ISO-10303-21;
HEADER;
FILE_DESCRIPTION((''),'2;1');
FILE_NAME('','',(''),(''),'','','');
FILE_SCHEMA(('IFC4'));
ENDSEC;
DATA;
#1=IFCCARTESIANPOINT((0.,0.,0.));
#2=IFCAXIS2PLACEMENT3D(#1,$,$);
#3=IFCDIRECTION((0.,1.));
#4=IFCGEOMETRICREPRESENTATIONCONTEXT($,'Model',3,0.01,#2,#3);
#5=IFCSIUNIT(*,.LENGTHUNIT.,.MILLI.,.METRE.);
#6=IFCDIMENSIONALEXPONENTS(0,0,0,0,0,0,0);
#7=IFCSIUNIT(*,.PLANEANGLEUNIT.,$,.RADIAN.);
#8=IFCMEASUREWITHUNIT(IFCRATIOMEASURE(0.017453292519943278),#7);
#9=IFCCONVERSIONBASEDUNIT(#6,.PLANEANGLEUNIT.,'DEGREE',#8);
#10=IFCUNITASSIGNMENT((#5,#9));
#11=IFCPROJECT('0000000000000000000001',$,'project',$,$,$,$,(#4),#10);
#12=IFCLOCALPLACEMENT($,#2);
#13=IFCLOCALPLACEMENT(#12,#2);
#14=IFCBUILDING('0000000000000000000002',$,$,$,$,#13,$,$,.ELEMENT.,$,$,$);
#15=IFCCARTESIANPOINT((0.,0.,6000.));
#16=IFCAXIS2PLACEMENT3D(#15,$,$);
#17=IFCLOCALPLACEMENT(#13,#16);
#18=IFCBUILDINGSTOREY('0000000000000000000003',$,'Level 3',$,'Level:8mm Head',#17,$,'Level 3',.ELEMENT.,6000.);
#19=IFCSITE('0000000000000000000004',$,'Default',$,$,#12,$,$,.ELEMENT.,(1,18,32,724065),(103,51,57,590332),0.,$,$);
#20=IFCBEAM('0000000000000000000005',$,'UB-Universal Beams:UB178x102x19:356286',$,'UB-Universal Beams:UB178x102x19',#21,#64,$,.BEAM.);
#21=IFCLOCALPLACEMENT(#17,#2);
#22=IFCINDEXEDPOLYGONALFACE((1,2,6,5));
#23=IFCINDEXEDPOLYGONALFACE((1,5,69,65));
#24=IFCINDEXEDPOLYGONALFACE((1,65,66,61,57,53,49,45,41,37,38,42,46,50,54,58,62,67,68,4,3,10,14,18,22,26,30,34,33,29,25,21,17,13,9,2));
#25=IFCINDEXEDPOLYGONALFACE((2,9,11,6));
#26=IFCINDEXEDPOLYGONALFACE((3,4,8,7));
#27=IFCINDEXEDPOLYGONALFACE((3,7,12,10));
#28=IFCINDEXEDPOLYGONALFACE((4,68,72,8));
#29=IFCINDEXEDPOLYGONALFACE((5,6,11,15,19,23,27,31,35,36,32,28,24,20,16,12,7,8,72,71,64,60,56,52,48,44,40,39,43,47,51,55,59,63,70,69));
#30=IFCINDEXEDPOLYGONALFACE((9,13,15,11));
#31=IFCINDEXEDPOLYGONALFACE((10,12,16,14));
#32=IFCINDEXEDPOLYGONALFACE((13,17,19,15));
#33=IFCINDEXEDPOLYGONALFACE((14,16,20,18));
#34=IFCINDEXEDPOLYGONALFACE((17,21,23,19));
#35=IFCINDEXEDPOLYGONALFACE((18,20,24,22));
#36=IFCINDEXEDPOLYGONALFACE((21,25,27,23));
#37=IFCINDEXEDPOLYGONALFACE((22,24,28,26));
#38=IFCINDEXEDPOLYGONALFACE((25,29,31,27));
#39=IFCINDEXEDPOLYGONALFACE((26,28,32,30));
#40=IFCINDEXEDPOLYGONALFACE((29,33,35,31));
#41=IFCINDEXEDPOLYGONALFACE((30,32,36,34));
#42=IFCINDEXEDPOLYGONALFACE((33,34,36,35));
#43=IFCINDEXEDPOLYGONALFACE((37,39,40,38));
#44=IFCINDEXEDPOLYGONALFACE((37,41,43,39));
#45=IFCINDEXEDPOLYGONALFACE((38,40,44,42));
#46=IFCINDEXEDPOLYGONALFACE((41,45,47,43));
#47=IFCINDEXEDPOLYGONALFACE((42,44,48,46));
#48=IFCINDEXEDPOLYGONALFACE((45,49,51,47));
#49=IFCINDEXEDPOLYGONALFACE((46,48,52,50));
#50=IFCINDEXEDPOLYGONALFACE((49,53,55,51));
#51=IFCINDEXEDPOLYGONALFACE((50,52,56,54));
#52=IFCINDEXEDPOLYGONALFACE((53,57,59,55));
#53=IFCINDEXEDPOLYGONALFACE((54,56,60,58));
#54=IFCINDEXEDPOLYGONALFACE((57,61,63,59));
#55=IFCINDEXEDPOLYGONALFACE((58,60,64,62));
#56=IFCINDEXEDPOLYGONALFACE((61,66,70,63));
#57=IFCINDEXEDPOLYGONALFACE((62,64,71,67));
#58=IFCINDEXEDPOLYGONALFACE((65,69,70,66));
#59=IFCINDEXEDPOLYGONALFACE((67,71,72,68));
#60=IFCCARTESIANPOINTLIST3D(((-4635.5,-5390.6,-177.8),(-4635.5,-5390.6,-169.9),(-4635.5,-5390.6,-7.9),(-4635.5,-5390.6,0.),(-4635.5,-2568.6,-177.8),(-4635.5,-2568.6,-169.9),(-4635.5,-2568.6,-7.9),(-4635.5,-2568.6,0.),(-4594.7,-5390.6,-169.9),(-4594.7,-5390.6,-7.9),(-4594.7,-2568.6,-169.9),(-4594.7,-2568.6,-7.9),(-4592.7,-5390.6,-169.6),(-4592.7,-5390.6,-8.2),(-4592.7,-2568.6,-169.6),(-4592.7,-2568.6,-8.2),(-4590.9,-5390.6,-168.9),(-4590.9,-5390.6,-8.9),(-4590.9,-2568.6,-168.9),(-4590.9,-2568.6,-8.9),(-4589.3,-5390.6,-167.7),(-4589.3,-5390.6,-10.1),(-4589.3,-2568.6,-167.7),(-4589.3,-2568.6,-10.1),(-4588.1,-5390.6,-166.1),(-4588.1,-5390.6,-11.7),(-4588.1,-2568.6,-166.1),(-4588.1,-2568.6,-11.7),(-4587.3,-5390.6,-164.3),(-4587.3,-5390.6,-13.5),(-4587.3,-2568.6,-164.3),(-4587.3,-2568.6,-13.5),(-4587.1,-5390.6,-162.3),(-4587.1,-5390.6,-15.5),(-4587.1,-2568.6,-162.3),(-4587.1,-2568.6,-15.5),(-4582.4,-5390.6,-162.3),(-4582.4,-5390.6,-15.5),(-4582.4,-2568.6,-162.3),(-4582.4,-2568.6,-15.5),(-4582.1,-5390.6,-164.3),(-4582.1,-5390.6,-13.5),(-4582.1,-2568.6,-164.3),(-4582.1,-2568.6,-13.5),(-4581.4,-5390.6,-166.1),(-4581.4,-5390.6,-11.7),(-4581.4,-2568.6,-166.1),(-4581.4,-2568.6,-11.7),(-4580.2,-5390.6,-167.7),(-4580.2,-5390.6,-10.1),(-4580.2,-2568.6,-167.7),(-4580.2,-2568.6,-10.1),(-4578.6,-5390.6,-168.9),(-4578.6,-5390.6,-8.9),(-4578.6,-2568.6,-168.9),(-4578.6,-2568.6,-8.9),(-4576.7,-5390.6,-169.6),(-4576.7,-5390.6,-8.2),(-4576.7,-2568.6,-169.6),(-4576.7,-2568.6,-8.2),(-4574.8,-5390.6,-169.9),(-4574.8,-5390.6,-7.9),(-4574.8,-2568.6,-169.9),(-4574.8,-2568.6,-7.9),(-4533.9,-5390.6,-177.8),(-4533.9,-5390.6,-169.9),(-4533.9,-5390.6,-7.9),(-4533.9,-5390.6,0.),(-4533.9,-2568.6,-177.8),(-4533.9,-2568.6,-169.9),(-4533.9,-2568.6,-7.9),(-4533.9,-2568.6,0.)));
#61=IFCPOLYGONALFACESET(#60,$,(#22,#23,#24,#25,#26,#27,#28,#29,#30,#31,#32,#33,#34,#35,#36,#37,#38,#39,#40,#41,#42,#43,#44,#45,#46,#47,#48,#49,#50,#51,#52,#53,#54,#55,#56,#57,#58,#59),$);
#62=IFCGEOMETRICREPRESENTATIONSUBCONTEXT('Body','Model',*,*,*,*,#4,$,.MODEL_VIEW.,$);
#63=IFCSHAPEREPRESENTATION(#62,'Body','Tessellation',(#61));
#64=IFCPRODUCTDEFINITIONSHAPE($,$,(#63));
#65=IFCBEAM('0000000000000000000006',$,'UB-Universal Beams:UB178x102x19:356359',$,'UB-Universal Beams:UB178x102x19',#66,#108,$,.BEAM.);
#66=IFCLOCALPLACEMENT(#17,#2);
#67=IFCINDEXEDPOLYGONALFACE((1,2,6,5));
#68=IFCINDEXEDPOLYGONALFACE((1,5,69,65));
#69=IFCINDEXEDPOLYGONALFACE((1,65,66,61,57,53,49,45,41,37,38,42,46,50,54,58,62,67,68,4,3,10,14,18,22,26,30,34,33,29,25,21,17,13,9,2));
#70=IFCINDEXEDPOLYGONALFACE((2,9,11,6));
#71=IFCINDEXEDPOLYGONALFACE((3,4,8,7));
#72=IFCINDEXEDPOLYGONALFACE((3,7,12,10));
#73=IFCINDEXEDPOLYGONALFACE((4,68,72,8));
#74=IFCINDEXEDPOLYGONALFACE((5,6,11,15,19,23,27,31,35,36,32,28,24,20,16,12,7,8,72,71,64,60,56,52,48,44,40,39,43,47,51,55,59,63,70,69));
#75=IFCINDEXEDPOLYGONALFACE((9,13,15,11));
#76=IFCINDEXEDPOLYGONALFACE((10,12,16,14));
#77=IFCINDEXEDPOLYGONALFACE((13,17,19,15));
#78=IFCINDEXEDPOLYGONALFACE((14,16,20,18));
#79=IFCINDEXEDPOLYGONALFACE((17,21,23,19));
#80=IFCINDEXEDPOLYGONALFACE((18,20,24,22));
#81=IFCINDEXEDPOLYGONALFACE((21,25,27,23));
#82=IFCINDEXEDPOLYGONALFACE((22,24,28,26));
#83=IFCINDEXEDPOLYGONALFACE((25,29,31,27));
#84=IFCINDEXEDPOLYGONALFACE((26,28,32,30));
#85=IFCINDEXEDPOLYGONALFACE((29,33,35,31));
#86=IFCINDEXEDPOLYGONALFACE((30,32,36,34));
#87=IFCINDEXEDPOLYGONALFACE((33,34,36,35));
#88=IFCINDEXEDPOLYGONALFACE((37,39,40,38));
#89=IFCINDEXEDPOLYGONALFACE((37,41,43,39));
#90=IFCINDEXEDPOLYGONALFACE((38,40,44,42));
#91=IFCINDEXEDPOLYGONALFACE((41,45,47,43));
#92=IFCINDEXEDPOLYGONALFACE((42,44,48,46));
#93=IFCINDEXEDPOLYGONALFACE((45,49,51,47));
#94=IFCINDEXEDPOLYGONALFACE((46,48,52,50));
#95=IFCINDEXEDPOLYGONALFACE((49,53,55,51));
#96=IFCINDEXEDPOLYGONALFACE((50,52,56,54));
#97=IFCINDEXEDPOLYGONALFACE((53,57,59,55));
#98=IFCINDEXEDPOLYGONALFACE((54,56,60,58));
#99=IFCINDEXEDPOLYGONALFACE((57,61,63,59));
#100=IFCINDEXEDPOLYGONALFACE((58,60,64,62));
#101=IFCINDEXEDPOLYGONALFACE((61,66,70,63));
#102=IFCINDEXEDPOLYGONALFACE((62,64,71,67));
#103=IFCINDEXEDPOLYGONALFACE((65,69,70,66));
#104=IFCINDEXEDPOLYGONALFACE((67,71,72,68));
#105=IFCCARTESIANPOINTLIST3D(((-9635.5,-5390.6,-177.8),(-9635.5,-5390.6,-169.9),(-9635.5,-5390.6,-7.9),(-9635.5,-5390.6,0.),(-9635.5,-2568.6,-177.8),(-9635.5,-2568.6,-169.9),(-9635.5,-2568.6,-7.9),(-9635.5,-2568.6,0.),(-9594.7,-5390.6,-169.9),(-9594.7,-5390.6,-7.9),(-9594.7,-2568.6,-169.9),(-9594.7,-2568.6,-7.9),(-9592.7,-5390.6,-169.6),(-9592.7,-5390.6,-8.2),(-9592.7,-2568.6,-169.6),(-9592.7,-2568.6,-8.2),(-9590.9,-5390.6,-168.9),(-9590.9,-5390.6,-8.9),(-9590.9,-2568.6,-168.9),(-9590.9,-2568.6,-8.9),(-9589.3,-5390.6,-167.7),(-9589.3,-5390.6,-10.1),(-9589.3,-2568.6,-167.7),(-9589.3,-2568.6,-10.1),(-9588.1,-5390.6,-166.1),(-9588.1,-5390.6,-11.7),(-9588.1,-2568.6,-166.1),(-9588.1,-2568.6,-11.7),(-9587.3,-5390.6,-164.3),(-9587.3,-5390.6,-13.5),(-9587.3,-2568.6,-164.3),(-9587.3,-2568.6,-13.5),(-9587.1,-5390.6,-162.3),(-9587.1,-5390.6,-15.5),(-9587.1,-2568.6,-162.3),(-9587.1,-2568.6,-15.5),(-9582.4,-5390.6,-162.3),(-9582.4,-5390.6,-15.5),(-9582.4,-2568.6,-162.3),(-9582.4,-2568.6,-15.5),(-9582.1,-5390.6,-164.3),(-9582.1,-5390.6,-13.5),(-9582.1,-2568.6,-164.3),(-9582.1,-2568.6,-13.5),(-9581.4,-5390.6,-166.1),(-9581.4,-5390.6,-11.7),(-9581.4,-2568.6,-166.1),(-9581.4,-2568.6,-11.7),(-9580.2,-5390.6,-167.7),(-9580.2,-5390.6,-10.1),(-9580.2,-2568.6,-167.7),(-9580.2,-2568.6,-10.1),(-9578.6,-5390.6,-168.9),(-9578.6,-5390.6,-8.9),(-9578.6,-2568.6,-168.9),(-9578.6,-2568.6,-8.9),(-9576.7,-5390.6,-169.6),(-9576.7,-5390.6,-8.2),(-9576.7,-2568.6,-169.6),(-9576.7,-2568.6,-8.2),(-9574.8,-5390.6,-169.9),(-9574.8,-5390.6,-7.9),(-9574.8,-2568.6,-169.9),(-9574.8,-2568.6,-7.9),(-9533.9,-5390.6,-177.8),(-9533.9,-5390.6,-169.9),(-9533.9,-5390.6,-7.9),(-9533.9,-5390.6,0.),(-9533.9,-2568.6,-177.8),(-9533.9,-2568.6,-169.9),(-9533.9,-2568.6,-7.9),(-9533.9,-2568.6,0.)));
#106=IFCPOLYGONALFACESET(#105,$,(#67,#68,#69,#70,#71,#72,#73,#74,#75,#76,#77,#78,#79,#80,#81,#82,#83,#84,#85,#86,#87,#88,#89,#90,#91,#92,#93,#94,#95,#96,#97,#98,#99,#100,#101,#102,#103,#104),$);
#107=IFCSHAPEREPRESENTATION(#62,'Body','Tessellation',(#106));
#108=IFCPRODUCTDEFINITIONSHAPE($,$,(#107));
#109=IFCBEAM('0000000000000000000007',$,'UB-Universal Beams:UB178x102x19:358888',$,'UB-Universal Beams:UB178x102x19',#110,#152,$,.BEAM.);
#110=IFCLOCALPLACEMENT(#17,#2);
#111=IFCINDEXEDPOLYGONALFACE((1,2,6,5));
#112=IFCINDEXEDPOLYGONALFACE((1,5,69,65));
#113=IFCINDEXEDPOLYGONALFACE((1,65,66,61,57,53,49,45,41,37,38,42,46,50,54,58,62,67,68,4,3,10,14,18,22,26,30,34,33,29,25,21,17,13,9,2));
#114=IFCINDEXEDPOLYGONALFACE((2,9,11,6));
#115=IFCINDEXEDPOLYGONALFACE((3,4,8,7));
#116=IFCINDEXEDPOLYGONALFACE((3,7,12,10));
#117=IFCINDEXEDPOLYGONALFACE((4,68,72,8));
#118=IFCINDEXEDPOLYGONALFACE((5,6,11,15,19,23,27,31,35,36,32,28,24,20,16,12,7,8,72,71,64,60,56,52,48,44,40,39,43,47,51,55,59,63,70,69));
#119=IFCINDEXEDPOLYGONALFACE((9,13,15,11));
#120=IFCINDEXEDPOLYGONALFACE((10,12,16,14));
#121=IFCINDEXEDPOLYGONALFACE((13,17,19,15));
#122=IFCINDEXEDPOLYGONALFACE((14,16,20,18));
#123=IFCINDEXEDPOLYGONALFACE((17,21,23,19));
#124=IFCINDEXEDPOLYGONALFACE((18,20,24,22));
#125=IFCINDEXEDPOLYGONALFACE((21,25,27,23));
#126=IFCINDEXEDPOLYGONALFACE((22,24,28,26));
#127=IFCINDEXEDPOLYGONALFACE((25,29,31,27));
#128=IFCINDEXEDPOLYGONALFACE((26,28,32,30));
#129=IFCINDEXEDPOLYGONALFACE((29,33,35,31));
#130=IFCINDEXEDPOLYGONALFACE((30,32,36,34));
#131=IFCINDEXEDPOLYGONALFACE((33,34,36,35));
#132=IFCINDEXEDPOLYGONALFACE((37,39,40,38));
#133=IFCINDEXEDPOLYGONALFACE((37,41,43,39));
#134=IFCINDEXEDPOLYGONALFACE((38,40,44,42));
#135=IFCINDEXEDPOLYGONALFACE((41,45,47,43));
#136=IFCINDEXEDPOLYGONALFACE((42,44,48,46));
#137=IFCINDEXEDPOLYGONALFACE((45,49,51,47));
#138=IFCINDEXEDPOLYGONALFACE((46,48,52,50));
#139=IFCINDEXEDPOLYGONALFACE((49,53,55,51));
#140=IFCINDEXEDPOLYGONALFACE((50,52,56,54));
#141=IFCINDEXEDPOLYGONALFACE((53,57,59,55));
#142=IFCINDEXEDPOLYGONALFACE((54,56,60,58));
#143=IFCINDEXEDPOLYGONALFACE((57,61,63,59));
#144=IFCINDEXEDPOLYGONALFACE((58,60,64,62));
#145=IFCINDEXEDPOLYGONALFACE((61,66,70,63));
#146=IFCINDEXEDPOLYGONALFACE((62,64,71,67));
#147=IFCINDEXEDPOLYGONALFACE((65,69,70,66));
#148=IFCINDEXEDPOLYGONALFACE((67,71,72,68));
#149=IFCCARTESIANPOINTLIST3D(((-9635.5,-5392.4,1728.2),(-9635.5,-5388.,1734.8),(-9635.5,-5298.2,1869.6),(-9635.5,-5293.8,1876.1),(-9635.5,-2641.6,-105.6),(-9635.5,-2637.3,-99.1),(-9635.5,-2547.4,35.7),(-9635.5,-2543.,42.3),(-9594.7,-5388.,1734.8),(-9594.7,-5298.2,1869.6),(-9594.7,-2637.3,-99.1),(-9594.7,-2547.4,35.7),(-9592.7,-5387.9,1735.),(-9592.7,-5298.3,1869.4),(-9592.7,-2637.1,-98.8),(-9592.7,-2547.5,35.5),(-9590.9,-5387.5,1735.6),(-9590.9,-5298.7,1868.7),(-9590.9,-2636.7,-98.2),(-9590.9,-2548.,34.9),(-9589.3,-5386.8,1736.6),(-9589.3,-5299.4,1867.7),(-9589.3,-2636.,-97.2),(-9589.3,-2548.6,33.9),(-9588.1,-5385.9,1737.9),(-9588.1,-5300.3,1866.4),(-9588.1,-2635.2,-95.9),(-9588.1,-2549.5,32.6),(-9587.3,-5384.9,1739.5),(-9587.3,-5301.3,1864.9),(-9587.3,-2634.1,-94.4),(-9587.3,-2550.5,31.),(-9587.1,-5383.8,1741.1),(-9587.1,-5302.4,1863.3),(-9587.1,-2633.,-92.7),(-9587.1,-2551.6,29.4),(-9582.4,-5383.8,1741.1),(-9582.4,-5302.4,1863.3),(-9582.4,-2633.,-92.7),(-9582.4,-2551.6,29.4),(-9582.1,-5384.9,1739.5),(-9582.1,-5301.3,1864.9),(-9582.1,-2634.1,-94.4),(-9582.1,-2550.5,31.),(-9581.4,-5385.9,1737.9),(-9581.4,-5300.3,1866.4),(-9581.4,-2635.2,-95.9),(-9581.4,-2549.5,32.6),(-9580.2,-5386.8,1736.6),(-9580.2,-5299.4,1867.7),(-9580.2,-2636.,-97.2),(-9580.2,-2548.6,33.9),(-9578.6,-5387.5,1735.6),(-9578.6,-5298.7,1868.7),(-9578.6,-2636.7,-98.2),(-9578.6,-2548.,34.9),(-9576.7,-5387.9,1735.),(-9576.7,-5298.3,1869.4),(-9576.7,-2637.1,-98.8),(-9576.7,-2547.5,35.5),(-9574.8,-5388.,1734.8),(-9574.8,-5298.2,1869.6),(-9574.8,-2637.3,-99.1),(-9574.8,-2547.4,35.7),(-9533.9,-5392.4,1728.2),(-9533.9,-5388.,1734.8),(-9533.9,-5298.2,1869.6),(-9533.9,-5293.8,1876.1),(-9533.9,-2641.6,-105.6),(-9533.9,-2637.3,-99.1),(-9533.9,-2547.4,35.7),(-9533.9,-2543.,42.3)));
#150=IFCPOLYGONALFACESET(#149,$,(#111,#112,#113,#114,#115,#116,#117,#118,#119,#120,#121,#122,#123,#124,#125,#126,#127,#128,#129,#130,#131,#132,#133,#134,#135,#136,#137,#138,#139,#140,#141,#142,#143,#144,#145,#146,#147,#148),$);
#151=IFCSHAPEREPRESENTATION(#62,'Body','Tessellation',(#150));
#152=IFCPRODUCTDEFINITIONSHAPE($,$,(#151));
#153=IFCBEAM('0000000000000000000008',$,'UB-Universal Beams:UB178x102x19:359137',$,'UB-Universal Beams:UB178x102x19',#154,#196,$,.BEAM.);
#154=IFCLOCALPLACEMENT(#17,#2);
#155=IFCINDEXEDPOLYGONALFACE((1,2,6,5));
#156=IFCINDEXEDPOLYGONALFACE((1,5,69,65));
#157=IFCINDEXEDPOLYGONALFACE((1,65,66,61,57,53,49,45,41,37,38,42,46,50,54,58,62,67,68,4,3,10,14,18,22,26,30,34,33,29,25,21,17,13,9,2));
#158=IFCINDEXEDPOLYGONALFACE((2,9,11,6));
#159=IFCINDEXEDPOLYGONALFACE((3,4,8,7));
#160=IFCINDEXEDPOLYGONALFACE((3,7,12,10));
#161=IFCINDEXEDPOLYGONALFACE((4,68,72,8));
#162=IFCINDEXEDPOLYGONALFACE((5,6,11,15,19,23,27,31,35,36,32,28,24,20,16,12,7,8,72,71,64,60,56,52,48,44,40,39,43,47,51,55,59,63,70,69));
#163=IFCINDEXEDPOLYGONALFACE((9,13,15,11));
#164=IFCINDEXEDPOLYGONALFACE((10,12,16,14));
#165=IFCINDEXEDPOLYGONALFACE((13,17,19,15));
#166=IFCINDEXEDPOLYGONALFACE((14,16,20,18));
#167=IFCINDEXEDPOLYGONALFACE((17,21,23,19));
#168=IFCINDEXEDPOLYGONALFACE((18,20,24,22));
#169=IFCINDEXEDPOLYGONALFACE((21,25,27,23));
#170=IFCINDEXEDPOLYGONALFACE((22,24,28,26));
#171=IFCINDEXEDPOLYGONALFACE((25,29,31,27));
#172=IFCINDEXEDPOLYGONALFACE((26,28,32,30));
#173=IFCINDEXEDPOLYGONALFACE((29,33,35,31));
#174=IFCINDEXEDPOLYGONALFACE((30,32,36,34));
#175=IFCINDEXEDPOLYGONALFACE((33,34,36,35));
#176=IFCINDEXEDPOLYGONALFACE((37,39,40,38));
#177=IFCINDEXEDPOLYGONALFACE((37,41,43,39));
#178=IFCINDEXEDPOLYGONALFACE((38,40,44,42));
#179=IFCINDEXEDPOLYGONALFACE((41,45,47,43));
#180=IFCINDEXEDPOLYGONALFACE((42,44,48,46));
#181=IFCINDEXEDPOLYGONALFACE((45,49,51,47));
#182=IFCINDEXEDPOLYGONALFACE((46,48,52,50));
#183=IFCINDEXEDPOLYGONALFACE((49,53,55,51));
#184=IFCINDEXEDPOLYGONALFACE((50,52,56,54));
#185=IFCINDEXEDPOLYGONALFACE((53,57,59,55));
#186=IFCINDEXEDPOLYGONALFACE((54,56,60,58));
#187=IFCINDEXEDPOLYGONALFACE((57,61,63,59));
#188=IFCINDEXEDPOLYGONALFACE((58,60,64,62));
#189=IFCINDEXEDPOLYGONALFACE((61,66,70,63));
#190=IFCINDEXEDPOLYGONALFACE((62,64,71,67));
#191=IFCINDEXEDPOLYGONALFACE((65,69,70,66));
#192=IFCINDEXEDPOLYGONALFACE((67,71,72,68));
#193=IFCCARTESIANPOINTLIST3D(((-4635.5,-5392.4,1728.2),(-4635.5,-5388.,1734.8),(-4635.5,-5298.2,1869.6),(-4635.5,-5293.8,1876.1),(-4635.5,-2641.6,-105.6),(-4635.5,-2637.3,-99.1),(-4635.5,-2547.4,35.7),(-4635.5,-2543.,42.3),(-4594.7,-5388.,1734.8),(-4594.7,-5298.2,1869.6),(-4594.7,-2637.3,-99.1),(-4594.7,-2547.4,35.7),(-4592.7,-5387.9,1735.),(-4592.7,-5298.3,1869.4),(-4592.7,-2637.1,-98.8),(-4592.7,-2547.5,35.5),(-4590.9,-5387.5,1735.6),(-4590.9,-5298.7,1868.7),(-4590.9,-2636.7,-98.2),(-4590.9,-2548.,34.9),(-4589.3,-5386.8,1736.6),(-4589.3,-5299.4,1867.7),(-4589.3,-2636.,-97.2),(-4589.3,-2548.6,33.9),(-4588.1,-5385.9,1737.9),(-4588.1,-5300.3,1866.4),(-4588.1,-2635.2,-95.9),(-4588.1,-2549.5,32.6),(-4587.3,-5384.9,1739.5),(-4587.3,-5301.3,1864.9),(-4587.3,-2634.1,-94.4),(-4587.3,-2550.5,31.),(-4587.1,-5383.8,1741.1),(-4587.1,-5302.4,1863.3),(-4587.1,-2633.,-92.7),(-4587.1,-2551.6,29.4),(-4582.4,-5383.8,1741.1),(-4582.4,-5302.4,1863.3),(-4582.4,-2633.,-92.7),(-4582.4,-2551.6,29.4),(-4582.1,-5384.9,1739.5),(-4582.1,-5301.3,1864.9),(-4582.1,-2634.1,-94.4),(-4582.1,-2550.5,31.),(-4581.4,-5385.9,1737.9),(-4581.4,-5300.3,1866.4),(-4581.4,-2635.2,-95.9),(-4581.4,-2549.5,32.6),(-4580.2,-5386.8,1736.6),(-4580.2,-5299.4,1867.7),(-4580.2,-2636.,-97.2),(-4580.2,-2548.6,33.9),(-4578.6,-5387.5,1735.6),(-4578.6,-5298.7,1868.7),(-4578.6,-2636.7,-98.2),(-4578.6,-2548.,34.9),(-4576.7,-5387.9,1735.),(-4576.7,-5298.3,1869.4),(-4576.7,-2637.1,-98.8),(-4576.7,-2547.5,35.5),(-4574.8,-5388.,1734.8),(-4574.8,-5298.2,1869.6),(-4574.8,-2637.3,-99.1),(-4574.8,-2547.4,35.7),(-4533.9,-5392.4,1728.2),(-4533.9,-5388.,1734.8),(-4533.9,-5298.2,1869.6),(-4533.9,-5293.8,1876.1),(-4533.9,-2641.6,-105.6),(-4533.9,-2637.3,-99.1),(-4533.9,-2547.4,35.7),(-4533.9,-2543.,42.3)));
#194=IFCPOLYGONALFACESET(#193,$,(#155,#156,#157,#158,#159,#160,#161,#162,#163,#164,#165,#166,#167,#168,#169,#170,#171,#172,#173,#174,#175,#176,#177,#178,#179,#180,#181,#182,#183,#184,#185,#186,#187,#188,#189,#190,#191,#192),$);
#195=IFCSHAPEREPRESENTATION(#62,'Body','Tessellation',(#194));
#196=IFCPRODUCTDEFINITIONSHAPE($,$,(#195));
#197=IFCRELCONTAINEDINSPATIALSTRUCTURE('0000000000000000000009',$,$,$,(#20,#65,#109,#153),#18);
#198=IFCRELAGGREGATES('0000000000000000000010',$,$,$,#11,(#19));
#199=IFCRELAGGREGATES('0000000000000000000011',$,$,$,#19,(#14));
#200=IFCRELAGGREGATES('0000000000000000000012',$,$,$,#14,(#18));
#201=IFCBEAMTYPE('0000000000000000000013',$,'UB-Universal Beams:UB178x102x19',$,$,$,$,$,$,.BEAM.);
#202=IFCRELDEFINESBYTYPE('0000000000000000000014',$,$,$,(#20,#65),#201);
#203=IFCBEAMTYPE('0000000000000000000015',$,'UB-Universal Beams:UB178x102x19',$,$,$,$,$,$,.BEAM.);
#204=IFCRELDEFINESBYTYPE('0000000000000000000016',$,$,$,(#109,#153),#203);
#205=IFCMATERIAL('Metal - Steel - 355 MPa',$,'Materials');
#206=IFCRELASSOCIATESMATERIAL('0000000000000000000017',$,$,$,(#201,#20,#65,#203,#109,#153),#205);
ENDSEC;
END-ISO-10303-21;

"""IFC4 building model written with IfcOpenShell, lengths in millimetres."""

from ifc_helpers import new_model, entity, si_unit, converted_unit, direction, frame, origin, place, context, subcontext, project, spatial, line, arc, indexed_curve, outline, extrude, source, transform, mapped, material, type_object, type_shapes, element, save


model = new_model("IFC4")

# Units and contexts
model_context = context("Model", 3, precision=0.01, world=origin(), true_north=direction((0.0, 1.0)))
body_context = subcontext(model_context, "Body", "Model", "MODEL_VIEW")
ifc_project = project(units=[si_unit("LENGTHUNIT", "METRE", prefix="MILLI"), converted_unit("PLANEANGLEUNIT", "DEGREE", entity("IfcRatioMeasure", 0.017453292519943278), si_unit("PLANEANGLEUNIT", "RADIAN"), dimensions=[0, 0, 0, 0, 0, 0, 0])], contexts=[model_context])

# Site, building, storey
site_placement = place(None, origin())
site = spatial("IfcSite", under=ifc_project, at=site_placement, Name="Default", CompositionType="ELEMENT", RefLatitude=(1, 18, 32, 724065), RefLongitude=(103, 51, 57, 590332), RefElevation=0.0)
building_placement = place(site_placement, origin())
building = spatial("IfcBuilding", under=site, at=building_placement, CompositionType="ELEMENT")
storey_placement = place(building_placement, frame((0.0, 0.0, 6000.0)))
storey = spatial("IfcBuildingStorey", under=building, at=storey_placement, Name="Level 3", ObjectType="Level:8mm Head", LongName="Level 3", CompositionType="ELEMENT", Elevation=6000.0)

# Shared definitions
ifc_material = material(Name="Metal - Steel - 355 MPa", Category="Materials")

# Beams
beam_type_1 = type_object("IfcBeamType", Name="UB-Universal Beams:UB178x102x19", PredefinedType="BEAM", material=ifc_material)
shared_shape_1 = source(origin(), body_context, "Body", "SweptSolid", [
    extrude(outline(indexed_curve([(-88.9, -50.8), (-81.0, -50.8), (-81.0, -9.9), (-78.8, -4.6), (-73.4, -2.3), (73.4, -2.3), (78.8, -4.6), (81.0, -9.9), (81.0, -50.8), (88.9, -50.8), (88.9, 50.8), (81.0, 50.8), (81.0, 10.0), (78.8, 4.6), (73.4, 2.4), (-73.4, 2.4), (-78.8, 4.6), (-81.0, 10.0), (-81.0, 50.8), (-88.9, 50.8)], segments=[line(1, 2, 3), arc(3, 4, 5), line(5, 6), arc(6, 7, 8), line(8, 9, 10, 11, 12, 13), arc(13, 14, 15), line(15, 16), arc(16, 17, 18), line(18, 19, 20, 1)], self_intersect=False)), frame((-1411.0, 0.0, 0.0), z_axis=(1.0, 0.0, 0.0), x_axis=(0.0, 0.0, -1.0)), (0.0, 0.0, 1.0), 2822.0),
])
type_shapes(beam_type_1, [shared_shape_1])
for number, where, z_axis, x_axis, name in (
    (1, (-4584.7, -3979.6, -88.9), (0.0, 0.0, 1.0), (0.0, 1.0, 0.0), "UB-Universal Beams:UB178x102x19:356286"),
    (2, (-9584.7, -3979.6, -88.9), (0.0, 0.0, 1.0), (0.0, -1.0, 0.0), "UB-Universal Beams:UB178x102x19:356359"),
):
    element("IfcBeam", number, at=place(storey_placement, frame(where, z_axis=z_axis, x_axis=x_axis)), inside=storey, type_object=beam_type_1, material=ifc_material, Name=name, ObjectType="UB-Universal Beams:UB178x102x19", PredefinedType="BEAM", context=body_context, shape_type="MappedRepresentation", body=[
        mapped(shared_shape_1, transform((0.0, 0.0, 0.0), scale=1.0)),
    ])
beam_type_2 = type_object("IfcBeamType", Name="UB-Universal Beams:UB178x102x19", PredefinedType="BEAM", material=ifc_material)
shared_shape_2 = source(origin(), body_context, "Body", "SweptSolid", [
    extrude(outline(indexed_curve([(-88.9, -50.8), (-81.0, -50.8), (-81.0, -9.9), (-78.8, -4.6), (-73.4, -2.3), (73.4, -2.3), (78.8, -4.6), (81.0, -9.9), (81.0, -50.8), (88.9, -50.8), (88.9, 50.8), (81.0, 50.8), (81.0, 10.0), (78.8, 4.6), (73.4, 2.4), (-73.4, 2.4), (-78.8, 4.6), (-81.0, 10.0), (-81.0, 50.8), (-88.9, 50.8)], segments=[line(1, 2, 3), arc(3, 4, 5), line(5, 6), arc(6, 7, 8), line(8, 9, 10, 11, 12, 13), arc(13, 14, 15), line(15, 16), arc(16, 17, 18), line(18, 19, 20, 1)], self_intersect=False)), frame((-1726.5, 0.0, 0.0), z_axis=(1.0, 0.0, 0.0), x_axis=(0.0, 0.0, -1.0)), (0.0, 0.0, 1.0), 3306.0),
])
type_shapes(beam_type_2, [shared_shape_2])
for number, where, z_axis, x_axis, name in (
    (3, (-9584.7, -4028.9, 926.0), (0.0, 0.5547, 0.83205), (0.0, -0.83205, 0.5547), "UB-Universal Beams:UB178x102x19:358888"),
    (4, (-4584.7, -4028.9, 926.0), (0.0, 0.5547, 0.83205), (0.0, -0.83205, 0.5547), "UB-Universal Beams:UB178x102x19:359137"),
):
    element("IfcBeam", number, at=place(storey_placement, frame(where, z_axis=z_axis, x_axis=x_axis)), inside=storey, type_object=beam_type_2, material=ifc_material, Name=name, ObjectType="UB-Universal Beams:UB178x102x19", PredefinedType="BEAM", context=body_context, shape_type="MappedRepresentation", body=[
        mapped(shared_shape_2, transform((0.0, 0.0, 0.0), scale=1.0)),
    ])

save(model, "model.ifc")
